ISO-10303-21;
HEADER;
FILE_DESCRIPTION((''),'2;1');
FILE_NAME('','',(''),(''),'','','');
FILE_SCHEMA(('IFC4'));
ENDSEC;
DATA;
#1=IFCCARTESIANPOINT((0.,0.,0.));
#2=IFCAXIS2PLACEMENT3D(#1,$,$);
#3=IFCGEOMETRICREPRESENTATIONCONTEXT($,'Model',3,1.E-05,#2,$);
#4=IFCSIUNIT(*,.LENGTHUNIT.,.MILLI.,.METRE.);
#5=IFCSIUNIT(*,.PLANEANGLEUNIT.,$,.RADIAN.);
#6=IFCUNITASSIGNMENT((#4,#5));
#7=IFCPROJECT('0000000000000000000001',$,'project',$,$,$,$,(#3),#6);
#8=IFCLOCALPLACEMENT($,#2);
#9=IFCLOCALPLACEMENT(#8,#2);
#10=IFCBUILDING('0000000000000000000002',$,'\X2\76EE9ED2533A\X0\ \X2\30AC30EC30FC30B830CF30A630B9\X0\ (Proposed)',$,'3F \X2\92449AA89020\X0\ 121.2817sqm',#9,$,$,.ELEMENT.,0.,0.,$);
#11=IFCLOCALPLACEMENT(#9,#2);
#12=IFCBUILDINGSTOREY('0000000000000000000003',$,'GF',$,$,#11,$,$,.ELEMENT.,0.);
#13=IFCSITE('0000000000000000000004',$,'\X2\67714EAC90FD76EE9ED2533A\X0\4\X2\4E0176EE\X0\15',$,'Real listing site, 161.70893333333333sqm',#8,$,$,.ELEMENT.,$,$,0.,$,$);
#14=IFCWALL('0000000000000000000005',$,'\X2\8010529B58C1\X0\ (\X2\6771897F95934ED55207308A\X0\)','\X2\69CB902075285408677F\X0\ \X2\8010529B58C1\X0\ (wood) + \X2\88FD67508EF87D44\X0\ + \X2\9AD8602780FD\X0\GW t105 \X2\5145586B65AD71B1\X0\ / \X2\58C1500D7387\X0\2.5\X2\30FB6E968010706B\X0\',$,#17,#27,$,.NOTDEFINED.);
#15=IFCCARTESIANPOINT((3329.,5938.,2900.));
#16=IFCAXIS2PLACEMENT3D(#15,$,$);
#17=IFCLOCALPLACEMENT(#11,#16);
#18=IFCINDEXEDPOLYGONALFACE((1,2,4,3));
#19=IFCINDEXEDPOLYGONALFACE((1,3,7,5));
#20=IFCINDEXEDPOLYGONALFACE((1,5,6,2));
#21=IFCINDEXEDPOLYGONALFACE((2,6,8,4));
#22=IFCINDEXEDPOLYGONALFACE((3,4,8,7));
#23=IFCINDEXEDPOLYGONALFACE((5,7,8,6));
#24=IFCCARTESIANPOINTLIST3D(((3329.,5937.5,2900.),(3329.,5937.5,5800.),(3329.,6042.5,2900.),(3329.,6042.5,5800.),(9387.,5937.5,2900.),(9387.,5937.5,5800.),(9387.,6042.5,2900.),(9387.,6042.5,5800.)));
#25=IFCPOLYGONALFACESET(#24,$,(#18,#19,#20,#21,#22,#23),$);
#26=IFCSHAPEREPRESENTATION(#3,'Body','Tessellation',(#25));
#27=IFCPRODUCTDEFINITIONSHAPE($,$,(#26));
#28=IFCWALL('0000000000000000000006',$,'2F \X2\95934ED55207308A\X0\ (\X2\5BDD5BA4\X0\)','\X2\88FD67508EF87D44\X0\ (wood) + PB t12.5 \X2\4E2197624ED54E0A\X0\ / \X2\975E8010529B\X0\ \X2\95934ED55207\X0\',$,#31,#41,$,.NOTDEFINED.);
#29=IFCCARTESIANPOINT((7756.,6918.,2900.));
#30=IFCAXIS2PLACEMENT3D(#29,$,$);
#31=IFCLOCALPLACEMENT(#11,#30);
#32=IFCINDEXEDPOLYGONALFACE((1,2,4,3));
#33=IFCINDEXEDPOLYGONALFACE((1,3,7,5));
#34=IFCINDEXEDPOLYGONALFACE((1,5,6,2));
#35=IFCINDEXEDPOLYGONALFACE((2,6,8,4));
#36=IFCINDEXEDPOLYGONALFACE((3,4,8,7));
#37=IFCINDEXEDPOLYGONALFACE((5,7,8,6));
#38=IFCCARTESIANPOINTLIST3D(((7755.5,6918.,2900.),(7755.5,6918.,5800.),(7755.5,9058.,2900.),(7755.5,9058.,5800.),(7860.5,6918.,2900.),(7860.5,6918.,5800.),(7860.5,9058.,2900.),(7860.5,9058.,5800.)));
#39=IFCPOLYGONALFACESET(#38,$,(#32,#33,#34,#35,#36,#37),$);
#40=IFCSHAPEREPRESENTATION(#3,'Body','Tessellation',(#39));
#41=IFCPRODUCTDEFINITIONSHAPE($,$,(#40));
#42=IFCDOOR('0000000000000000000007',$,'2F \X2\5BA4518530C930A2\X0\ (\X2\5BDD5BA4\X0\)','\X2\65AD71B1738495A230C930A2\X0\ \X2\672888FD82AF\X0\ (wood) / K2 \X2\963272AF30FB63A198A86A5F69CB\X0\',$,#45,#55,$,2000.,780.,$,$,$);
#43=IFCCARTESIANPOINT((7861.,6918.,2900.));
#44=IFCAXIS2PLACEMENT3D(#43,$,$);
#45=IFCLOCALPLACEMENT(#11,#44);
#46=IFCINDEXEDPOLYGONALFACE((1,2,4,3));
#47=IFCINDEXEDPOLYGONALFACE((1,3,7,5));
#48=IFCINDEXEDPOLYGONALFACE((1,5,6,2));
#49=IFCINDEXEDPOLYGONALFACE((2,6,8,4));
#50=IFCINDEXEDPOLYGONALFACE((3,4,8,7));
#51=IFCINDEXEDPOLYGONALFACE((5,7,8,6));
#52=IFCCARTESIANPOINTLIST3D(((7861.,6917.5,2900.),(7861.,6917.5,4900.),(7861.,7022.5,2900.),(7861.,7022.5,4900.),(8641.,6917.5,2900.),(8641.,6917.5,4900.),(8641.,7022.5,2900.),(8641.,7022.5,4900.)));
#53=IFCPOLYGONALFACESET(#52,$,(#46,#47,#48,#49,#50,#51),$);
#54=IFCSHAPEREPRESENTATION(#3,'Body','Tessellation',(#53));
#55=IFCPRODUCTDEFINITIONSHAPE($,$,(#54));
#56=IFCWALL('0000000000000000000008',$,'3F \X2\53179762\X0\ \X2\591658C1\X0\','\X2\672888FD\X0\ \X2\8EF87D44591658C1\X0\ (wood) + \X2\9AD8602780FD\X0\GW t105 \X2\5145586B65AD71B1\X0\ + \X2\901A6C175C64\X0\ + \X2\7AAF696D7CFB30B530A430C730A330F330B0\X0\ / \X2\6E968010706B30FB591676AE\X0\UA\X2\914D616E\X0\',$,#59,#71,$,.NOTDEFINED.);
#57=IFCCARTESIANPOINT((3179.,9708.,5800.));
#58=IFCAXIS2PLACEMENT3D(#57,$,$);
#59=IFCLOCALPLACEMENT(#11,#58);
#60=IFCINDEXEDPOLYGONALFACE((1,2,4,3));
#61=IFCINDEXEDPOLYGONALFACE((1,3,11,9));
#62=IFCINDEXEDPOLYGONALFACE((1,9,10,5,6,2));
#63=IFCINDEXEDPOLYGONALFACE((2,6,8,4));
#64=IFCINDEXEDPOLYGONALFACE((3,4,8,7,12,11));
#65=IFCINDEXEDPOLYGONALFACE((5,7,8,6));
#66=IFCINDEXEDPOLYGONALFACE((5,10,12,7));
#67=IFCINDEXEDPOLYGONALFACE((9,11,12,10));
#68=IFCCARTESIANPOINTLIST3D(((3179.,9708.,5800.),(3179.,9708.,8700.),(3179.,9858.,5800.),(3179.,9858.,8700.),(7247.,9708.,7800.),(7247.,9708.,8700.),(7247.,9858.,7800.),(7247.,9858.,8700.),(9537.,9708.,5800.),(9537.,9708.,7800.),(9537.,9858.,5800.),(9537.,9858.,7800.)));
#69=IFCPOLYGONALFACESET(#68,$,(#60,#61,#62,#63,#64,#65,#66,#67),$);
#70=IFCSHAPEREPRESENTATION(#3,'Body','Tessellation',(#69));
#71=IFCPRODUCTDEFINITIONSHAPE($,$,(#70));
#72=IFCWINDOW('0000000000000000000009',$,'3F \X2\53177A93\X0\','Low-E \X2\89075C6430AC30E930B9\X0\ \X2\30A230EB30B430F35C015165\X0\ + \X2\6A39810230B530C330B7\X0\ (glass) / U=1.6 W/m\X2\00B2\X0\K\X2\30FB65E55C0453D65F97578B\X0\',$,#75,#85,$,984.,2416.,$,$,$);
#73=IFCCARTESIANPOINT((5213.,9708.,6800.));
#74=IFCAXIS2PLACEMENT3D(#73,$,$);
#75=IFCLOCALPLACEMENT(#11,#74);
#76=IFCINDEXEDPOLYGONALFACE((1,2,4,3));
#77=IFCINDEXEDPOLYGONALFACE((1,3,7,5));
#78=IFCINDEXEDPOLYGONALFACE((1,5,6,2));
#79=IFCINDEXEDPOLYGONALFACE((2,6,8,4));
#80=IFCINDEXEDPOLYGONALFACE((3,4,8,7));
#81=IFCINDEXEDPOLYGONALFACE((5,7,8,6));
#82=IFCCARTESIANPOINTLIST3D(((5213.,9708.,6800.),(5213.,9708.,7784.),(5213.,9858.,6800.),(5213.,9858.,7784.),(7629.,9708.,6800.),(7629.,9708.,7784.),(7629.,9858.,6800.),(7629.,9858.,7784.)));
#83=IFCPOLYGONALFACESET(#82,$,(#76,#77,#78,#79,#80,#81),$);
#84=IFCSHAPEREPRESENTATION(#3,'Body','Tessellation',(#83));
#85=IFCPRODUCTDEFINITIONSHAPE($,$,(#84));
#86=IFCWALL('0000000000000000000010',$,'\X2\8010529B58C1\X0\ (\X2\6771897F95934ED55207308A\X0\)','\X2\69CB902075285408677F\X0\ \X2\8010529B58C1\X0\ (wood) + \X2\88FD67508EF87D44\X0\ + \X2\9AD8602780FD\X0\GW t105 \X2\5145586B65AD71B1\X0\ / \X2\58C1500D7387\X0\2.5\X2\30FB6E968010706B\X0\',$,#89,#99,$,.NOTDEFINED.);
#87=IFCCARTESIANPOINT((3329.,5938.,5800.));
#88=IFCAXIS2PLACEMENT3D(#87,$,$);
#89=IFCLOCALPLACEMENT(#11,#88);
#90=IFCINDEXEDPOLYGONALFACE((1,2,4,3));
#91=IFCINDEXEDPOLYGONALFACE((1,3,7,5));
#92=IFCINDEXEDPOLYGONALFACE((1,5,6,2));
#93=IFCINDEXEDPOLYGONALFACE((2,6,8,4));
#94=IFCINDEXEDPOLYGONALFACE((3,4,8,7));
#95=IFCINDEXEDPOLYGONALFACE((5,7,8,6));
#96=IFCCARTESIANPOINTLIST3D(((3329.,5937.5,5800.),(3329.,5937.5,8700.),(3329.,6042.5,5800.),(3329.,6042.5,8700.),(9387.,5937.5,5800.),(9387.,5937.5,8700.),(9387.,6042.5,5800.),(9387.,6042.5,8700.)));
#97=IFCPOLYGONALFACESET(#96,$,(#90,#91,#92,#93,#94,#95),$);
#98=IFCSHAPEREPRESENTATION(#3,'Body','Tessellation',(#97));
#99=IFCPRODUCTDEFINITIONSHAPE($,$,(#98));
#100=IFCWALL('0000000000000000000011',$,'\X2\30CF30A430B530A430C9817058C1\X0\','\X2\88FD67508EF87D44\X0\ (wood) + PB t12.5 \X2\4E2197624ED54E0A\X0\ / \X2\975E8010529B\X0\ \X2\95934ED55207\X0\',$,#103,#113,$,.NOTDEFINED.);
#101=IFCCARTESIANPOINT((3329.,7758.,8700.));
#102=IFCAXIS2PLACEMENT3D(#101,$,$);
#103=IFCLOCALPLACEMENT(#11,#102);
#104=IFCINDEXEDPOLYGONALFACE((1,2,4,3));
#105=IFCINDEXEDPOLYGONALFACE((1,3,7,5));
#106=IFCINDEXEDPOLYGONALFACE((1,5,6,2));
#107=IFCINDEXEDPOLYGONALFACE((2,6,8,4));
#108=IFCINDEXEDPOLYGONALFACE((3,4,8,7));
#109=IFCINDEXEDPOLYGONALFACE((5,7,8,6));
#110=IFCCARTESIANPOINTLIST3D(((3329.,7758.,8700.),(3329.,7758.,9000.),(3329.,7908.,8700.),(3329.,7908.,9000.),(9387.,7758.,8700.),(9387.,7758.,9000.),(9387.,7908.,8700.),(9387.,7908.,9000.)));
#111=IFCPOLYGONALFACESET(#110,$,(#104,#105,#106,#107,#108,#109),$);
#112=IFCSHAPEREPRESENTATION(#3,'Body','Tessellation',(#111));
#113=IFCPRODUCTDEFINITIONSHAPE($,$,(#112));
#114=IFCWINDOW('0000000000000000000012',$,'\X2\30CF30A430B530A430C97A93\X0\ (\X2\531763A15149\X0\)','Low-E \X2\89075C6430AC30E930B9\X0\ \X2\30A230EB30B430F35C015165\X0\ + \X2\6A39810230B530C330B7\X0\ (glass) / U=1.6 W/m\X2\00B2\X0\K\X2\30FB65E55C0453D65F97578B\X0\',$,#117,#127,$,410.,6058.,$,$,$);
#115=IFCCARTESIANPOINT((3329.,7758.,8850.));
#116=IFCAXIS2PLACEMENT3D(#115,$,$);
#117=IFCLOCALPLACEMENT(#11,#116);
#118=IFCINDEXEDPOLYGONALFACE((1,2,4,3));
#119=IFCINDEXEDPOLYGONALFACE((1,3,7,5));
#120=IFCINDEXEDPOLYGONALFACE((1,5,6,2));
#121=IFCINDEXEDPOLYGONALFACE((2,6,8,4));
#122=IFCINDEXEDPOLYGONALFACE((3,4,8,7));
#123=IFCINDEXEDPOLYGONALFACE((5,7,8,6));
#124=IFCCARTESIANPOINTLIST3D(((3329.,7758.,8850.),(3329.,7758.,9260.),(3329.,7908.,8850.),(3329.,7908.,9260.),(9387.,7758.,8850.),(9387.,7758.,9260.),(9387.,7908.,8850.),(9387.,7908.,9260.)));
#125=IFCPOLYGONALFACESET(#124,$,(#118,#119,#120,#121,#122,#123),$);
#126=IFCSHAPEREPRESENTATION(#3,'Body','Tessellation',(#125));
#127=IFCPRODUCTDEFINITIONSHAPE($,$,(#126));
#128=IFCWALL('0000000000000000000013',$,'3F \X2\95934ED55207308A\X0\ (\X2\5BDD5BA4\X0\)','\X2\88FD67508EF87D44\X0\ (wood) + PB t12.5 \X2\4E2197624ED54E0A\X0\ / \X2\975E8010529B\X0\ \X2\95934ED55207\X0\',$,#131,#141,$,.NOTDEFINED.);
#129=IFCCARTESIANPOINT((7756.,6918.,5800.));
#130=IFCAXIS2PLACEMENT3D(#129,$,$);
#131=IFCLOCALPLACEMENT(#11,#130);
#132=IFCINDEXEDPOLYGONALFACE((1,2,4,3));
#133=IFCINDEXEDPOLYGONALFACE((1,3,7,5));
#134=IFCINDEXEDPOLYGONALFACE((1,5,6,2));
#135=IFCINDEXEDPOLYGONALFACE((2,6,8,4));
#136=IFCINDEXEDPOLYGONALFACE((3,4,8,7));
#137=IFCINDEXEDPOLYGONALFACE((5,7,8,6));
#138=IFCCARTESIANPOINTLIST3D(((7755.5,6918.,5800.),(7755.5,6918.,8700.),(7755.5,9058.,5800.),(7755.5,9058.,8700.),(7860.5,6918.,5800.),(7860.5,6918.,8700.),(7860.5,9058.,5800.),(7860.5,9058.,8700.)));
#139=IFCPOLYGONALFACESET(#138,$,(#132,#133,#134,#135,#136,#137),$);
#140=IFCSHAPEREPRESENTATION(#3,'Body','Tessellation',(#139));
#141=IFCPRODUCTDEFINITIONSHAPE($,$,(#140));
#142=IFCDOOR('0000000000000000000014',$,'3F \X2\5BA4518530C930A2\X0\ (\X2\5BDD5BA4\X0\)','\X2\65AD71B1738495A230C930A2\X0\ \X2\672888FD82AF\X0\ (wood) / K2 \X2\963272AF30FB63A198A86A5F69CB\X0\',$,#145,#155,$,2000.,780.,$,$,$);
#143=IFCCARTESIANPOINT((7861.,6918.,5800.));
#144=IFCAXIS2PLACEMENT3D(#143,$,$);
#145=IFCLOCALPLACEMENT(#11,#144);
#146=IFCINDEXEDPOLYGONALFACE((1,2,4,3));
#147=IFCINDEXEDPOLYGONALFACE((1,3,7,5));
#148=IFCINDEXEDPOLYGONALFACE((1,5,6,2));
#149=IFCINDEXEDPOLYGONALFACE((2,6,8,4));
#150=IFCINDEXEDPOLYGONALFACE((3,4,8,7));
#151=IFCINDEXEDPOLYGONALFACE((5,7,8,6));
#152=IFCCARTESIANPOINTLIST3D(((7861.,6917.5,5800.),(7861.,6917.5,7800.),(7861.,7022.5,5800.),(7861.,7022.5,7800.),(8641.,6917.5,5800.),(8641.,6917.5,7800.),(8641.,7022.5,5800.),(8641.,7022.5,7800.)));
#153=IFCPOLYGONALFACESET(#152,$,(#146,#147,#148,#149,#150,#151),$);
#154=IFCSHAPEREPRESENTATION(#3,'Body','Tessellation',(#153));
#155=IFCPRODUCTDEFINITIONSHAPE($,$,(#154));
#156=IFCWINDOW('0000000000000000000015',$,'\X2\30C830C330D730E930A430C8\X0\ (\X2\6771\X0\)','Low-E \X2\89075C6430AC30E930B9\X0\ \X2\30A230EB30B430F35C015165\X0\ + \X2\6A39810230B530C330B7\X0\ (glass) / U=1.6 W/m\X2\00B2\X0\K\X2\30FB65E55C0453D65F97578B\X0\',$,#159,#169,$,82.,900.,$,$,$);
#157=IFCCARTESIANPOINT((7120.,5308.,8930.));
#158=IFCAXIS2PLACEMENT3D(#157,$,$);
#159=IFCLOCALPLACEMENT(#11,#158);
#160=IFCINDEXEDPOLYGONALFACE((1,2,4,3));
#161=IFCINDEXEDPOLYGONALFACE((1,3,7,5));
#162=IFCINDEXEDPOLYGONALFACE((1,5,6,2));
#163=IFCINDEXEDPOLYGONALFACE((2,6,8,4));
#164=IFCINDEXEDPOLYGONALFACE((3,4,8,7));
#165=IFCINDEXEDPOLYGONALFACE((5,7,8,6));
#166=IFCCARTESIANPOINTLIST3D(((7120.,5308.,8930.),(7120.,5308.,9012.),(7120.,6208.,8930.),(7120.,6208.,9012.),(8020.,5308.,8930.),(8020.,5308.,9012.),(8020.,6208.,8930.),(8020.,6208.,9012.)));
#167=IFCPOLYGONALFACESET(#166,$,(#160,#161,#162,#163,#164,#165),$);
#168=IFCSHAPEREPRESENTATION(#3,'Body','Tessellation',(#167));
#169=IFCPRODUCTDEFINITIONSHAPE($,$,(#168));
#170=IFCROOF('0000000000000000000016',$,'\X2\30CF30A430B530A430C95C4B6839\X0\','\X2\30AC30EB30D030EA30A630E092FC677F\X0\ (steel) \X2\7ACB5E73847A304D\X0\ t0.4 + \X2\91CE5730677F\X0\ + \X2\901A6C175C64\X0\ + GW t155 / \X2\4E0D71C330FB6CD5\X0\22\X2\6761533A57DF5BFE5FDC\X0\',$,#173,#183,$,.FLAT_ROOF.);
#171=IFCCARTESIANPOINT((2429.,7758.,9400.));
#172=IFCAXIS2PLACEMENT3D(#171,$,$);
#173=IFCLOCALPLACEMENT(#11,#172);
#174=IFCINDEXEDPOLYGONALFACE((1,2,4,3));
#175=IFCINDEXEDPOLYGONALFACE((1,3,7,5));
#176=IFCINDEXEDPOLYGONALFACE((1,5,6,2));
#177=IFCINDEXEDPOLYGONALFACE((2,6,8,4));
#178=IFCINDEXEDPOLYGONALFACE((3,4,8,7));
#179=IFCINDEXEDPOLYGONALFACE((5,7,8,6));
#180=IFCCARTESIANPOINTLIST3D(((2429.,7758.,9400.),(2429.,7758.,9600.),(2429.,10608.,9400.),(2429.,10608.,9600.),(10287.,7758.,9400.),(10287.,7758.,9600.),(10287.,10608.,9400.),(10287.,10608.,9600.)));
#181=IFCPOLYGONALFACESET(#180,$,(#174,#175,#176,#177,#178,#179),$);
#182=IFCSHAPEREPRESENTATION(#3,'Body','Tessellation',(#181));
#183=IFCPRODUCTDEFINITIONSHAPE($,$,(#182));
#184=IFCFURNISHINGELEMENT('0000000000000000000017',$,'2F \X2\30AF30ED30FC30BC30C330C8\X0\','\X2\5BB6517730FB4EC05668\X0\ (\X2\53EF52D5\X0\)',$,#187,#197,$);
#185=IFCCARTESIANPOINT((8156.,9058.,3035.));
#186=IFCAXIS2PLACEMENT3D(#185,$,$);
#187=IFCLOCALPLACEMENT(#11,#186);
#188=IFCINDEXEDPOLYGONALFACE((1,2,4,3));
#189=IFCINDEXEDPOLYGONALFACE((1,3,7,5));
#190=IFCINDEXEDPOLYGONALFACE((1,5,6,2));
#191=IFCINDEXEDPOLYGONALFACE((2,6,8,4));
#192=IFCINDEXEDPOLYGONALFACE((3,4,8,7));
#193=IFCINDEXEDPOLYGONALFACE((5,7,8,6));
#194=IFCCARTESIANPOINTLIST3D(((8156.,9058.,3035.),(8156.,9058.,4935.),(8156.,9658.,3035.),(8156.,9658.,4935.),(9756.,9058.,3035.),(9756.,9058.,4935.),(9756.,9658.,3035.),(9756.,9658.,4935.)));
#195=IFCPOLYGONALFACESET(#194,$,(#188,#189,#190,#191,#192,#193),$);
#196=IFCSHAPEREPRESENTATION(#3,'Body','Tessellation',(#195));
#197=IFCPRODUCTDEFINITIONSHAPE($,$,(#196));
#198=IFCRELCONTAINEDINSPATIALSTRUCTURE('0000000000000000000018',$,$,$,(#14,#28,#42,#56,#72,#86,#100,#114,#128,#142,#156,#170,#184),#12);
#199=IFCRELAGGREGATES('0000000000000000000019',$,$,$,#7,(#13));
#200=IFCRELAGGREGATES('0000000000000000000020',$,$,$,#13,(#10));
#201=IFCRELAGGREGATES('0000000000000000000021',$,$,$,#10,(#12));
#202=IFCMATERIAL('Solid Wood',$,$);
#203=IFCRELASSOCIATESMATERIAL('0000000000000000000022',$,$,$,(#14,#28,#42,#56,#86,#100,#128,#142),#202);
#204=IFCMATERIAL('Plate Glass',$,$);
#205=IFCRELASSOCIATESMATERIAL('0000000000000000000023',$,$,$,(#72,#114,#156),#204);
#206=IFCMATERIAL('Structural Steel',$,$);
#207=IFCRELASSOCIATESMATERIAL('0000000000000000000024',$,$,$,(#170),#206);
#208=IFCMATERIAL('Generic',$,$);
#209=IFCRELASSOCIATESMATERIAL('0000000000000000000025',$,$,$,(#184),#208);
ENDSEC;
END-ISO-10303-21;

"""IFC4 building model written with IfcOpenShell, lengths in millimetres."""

from ifc_helpers import new_model, si_unit, frame, frame_2d, origin, place, context, project, spatial, rectangle, extrude, material, element, fill, save


model = new_model("IFC4")

# Units and contexts
model_context = context("Model", 3, precision=1e-05, world=origin())
ifc_project = project(units=[si_unit("LENGTHUNIT", "METRE", prefix="MILLI"), si_unit("PLANEANGLEUNIT", "RADIAN")], contexts=[model_context])

# Site, building, storey
site_placement = place(None, origin())
site = spatial("IfcSite", under=ifc_project, at=site_placement, Name="東京都目黒区4丁目15", ObjectType="Real listing site, 161.70893333333333sqm", CompositionType="ELEMENT", RefElevation=0.0)
building_placement = place(site_placement, origin())
building = spatial("IfcBuilding", under=site, at=building_placement, Name="目黒区 ガレージハウス (Proposed)", ObjectType="3F 鉄骨造 121.2817sqm", CompositionType="ELEMENT", ElevationOfRefHeight=0.0, ElevationOfTerrain=0.0)
storey_placement = place(building_placement, origin())
storey = spatial("IfcBuildingStorey", under=building, at=storey_placement, Name="GF", CompositionType="ELEMENT", Elevation=0.0)

# Walls
ifc_material_1 = material(Name="Solid Wood")
wall_1_placement = place(storey_placement, frame((3329.0, 5938.0, 2900.0)))
element("IfcWall", 1, at=wall_1_placement, inside=storey, material=ifc_material_1, Name="耐力壁 (東西間仕切り)", Description="構造用合板 耐力壁 (wood) + 製材軸組 + 高性能GW t105 充填断熱 / 壁倍率2.5・準耐火", PredefinedType="NOTDEFINED", context=model_context, shape_type="SweptSolid", body=[
    extrude(rectangle(XDim=6058.0, YDim=105.0, at=frame_2d((3029.0, 52.0))), frame((3329.0, 5938.0, 2900.0)), (0.0, 0.0, 1.0), 2900.0),
])
wall_2_placement = place(storey_placement, frame((7756.0, 6918.0, 2900.0)))
element("IfcWall", 2, at=wall_2_placement, inside=storey, material=ifc_material_1, Name="2F 間仕切り (寝室)", Description="製材軸組 (wood) + PB t12.5 両面仕上 / 非耐力 間仕切", PredefinedType="NOTDEFINED", context=model_context, shape_type="SweptSolid", body=[
    extrude(rectangle(XDim=105.0, YDim=2140.0, at=frame_2d((52.0, 1070.0))), frame((7756.0, 6918.0, 2900.0)), (0.0, 0.0, 1.0), 2900.0),
])

# Door
door_1_placement = place(storey_placement, frame((7861.0, 6918.0, 2900.0)))
element("IfcDoor", 3, at=door_1_placement, inside=storey, material=ifc_material_1, Name="2F 室内ドア (寝室)", Description="断熱玄関ドア 木製芯 (wood) / K2 防犯・採風機構", OverallHeight=2000.0, OverallWidth=780.0, context=model_context, shape_type="SweptSolid", body=[
    extrude(rectangle(XDim=780.0, YDim=105.0, at=frame_2d((390.0, 52.0))), frame((7861.0, 6918.0, 2900.0)), (0.0, 0.0, 1.0), 2000.0),
])

# Wall, opening, window
wall_3_placement = place(storey_placement, frame((3179.0, 9708.0, 5800.0)))
wall_3 = element("IfcWall", 4, at=wall_3_placement, inside=storey, material=ifc_material_1, Name="3F 北面 外壁", Description="木製 軸組外壁 (wood) + 高性能GW t105 充填断熱 + 通気層 + 窯業系サイディング / 準耐火・外皮UA配慮", PredefinedType="NOTDEFINED", context=model_context, shape_type="SweptSolid", body=[
    extrude(rectangle(XDim=6358.0, YDim=150.0, at=frame_2d((3179.0, 75.0))), frame((3179.0, 9708.0, 5800.0)), (0.0, 0.0, 1.0), 2900.0),
])
opening_1_placement = place(storey_placement, frame((5213.0, 9708.0, 6800.0)))
opening_1 = element("IfcOpeningElement", 5, at=opening_1_placement, cuts=wall_3, PredefinedType="NOTDEFINED", context=model_context, shape_type="SweptSolid", body=[
    extrude(rectangle(XDim=2416.0, YDim=150.0, at=frame_2d((1208.0, 75.0))), frame((5213.0, 9708.0, 6800.0)), (0.0, 0.0, 1.0), 984.0),
])
ifc_material_2 = material(Name="Plate Glass")
window_1_placement = place(storey_placement, frame((5213.0, 9708.0, 6800.0)))
window_1 = element("IfcWindow", 6, at=window_1_placement, inside=storey, material=ifc_material_2, Name="3F 北窓", Description="Low-E 複層ガラス アルゴン封入 + 樹脂サッシ (glass) / U=1.6 W/m²K・日射取得型", OverallHeight=984.0, OverallWidth=2416.0, context=model_context, shape_type="SweptSolid", body=[
    extrude(rectangle(XDim=2416.0, YDim=150.0, at=frame_2d((1208.0, 75.0))), frame((5213.0, 9708.0, 6800.0)), (0.0, 0.0, 1.0), 984.0),
])
fill(opening_1, window_1)

# Wall
wall_4_placement = place(storey_placement, frame((3329.0, 5938.0, 5800.0)))
element("IfcWall", 7, at=wall_4_placement, inside=storey, material=ifc_material_1, Name="耐力壁 (東西間仕切り)", Description="構造用合板 耐力壁 (wood) + 製材軸組 + 高性能GW t105 充填断熱 / 壁倍率2.5・準耐火", PredefinedType="NOTDEFINED", context=model_context, shape_type="SweptSolid", body=[
    extrude(rectangle(XDim=6058.0, YDim=105.0, at=frame_2d((3029.0, 52.0))), frame((3329.0, 5938.0, 5800.0)), (0.0, 0.0, 1.0), 2900.0),
])

# Wall, opening, window
wall_5_placement = place(storey_placement, frame((3329.0, 7758.0, 8700.0)))
wall_5 = element("IfcWall", 8, at=wall_5_placement, inside=storey, material=ifc_material_1, Name="ハイサイド腰壁", Description="製材軸組 (wood) + PB t12.5 両面仕上 / 非耐力 間仕切", PredefinedType="NOTDEFINED", context=model_context, shape_type="SweptSolid", body=[
    extrude(rectangle(XDim=6058.0, YDim=150.0, at=frame_2d((3029.0, 75.0))), frame((3329.0, 7758.0, 8700.0)), (0.0, 0.0, 1.0), 700.0),
])
opening_2_placement = place(storey_placement, frame((3329.0, 7758.0, 8850.0)))
opening_2 = element("IfcOpeningElement", 9, at=opening_2_placement, cuts=wall_5, PredefinedType="NOTDEFINED", context=model_context, shape_type="SweptSolid", body=[
    extrude(rectangle(XDim=6058.0, YDim=150.0, at=frame_2d((3029.0, 75.0))), frame((3329.0, 7758.0, 8850.0)), (0.0, 0.0, 1.0), 410.0),
])
window_2_placement = place(storey_placement, frame((3329.0, 7758.0, 8850.0)))
window_2 = element("IfcWindow", 10, at=window_2_placement, inside=storey, material=ifc_material_2, Name="ハイサイド窓 (北採光)", Description="Low-E 複層ガラス アルゴン封入 + 樹脂サッシ (glass) / U=1.6 W/m²K・日射取得型", OverallHeight=410.0, OverallWidth=6058.0, context=model_context, shape_type="SweptSolid", body=[
    extrude(rectangle(XDim=6058.0, YDim=150.0, at=frame_2d((3029.0, 75.0))), frame((3329.0, 7758.0, 8850.0)), (0.0, 0.0, 1.0), 410.0),
])
fill(opening_2, window_2)

# Wall
wall_6_placement = place(storey_placement, frame((7756.0, 6918.0, 5800.0)))
element("IfcWall", 11, at=wall_6_placement, inside=storey, material=ifc_material_1, Name="3F 間仕切り (寝室)", Description="製材軸組 (wood) + PB t12.5 両面仕上 / 非耐力 間仕切", PredefinedType="NOTDEFINED", context=model_context, shape_type="SweptSolid", body=[
    extrude(rectangle(XDim=105.0, YDim=2140.0, at=frame_2d((52.0, 1070.0))), frame((7756.0, 6918.0, 5800.0)), (0.0, 0.0, 1.0), 2900.0),
])

# Door
door_2_placement = place(storey_placement, frame((7861.0, 6918.0, 5800.0)))
element("IfcDoor", 12, at=door_2_placement, inside=storey, material=ifc_material_1, Name="3F 室内ドア (寝室)", Description="断熱玄関ドア 木製芯 (wood) / K2 防犯・採風機構", OverallHeight=2000.0, OverallWidth=780.0, context=model_context, shape_type="SweptSolid", body=[
    extrude(rectangle(XDim=780.0, YDim=105.0, at=frame_2d((390.0, 52.0))), frame((7861.0, 6918.0, 5800.0)), (0.0, 0.0, 1.0), 2000.0),
])

# Window
window_3_placement = place(storey_placement, frame((7120.0, 5308.0, 8930.0)))
element("IfcWindow", 13, at=window_3_placement, inside=storey, material=ifc_material_2, Name="トップライト (東)", Description="Low-E 複層ガラス アルゴン封入 + 樹脂サッシ (glass) / U=1.6 W/m²K・日射取得型", OverallHeight=82.0, OverallWidth=900.0, context=model_context, shape_type="SweptSolid", body=[
    extrude(rectangle(XDim=900.0, YDim=900.0, at=frame_2d((450.0, 450.0))), frame((7120.0, 5308.0, 8930.0)), (0.0, 0.0, 1.0), 82.0),
])

# Roof
ifc_material_3 = material(Name="Structural Steel")
roof_placement = place(storey_placement, frame((2429.0, 7758.0, 9400.0)))
element("IfcRoof", 14, at=roof_placement, inside=storey, material=ifc_material_3, Name="ハイサイド屋根", Description="ガルバリウム鋼板 (steel) 立平葺き t0.4 + 野地板 + 通気層 + GW t155 / 不燃・法22条区域対応", PredefinedType="FLAT_ROOF", context=model_context, shape_type="SweptSolid", body=[
    extrude(rectangle(XDim=7858.0, YDim=2850.0, at=frame_2d((3929.0, 1425.0))), frame((2429.0, 7758.0, 9400.0)), (0.0, 0.0, 1.0), 200.0),
])

# Furnishing element
ifc_material_4 = material(Name="Generic")
furnishing_1_placement = place(storey_placement, frame((8156.0, 9058.0, 3035.0)))
element("IfcFurnishingElement", 15, at=furnishing_1_placement, inside=storey, material=ifc_material_4, Name="2F クローゼット", Description="家具・什器 (可動)", context=model_context, shape_type="SweptSolid", body=[
    extrude(rectangle(XDim=1600.0, YDim=600.0, at=frame_2d((800.0, 300.0))), frame((8156.0, 9058.0, 3035.0)), (0.0, 0.0, 1.0), 1900.0),
])

save(model, "model.ifc")
